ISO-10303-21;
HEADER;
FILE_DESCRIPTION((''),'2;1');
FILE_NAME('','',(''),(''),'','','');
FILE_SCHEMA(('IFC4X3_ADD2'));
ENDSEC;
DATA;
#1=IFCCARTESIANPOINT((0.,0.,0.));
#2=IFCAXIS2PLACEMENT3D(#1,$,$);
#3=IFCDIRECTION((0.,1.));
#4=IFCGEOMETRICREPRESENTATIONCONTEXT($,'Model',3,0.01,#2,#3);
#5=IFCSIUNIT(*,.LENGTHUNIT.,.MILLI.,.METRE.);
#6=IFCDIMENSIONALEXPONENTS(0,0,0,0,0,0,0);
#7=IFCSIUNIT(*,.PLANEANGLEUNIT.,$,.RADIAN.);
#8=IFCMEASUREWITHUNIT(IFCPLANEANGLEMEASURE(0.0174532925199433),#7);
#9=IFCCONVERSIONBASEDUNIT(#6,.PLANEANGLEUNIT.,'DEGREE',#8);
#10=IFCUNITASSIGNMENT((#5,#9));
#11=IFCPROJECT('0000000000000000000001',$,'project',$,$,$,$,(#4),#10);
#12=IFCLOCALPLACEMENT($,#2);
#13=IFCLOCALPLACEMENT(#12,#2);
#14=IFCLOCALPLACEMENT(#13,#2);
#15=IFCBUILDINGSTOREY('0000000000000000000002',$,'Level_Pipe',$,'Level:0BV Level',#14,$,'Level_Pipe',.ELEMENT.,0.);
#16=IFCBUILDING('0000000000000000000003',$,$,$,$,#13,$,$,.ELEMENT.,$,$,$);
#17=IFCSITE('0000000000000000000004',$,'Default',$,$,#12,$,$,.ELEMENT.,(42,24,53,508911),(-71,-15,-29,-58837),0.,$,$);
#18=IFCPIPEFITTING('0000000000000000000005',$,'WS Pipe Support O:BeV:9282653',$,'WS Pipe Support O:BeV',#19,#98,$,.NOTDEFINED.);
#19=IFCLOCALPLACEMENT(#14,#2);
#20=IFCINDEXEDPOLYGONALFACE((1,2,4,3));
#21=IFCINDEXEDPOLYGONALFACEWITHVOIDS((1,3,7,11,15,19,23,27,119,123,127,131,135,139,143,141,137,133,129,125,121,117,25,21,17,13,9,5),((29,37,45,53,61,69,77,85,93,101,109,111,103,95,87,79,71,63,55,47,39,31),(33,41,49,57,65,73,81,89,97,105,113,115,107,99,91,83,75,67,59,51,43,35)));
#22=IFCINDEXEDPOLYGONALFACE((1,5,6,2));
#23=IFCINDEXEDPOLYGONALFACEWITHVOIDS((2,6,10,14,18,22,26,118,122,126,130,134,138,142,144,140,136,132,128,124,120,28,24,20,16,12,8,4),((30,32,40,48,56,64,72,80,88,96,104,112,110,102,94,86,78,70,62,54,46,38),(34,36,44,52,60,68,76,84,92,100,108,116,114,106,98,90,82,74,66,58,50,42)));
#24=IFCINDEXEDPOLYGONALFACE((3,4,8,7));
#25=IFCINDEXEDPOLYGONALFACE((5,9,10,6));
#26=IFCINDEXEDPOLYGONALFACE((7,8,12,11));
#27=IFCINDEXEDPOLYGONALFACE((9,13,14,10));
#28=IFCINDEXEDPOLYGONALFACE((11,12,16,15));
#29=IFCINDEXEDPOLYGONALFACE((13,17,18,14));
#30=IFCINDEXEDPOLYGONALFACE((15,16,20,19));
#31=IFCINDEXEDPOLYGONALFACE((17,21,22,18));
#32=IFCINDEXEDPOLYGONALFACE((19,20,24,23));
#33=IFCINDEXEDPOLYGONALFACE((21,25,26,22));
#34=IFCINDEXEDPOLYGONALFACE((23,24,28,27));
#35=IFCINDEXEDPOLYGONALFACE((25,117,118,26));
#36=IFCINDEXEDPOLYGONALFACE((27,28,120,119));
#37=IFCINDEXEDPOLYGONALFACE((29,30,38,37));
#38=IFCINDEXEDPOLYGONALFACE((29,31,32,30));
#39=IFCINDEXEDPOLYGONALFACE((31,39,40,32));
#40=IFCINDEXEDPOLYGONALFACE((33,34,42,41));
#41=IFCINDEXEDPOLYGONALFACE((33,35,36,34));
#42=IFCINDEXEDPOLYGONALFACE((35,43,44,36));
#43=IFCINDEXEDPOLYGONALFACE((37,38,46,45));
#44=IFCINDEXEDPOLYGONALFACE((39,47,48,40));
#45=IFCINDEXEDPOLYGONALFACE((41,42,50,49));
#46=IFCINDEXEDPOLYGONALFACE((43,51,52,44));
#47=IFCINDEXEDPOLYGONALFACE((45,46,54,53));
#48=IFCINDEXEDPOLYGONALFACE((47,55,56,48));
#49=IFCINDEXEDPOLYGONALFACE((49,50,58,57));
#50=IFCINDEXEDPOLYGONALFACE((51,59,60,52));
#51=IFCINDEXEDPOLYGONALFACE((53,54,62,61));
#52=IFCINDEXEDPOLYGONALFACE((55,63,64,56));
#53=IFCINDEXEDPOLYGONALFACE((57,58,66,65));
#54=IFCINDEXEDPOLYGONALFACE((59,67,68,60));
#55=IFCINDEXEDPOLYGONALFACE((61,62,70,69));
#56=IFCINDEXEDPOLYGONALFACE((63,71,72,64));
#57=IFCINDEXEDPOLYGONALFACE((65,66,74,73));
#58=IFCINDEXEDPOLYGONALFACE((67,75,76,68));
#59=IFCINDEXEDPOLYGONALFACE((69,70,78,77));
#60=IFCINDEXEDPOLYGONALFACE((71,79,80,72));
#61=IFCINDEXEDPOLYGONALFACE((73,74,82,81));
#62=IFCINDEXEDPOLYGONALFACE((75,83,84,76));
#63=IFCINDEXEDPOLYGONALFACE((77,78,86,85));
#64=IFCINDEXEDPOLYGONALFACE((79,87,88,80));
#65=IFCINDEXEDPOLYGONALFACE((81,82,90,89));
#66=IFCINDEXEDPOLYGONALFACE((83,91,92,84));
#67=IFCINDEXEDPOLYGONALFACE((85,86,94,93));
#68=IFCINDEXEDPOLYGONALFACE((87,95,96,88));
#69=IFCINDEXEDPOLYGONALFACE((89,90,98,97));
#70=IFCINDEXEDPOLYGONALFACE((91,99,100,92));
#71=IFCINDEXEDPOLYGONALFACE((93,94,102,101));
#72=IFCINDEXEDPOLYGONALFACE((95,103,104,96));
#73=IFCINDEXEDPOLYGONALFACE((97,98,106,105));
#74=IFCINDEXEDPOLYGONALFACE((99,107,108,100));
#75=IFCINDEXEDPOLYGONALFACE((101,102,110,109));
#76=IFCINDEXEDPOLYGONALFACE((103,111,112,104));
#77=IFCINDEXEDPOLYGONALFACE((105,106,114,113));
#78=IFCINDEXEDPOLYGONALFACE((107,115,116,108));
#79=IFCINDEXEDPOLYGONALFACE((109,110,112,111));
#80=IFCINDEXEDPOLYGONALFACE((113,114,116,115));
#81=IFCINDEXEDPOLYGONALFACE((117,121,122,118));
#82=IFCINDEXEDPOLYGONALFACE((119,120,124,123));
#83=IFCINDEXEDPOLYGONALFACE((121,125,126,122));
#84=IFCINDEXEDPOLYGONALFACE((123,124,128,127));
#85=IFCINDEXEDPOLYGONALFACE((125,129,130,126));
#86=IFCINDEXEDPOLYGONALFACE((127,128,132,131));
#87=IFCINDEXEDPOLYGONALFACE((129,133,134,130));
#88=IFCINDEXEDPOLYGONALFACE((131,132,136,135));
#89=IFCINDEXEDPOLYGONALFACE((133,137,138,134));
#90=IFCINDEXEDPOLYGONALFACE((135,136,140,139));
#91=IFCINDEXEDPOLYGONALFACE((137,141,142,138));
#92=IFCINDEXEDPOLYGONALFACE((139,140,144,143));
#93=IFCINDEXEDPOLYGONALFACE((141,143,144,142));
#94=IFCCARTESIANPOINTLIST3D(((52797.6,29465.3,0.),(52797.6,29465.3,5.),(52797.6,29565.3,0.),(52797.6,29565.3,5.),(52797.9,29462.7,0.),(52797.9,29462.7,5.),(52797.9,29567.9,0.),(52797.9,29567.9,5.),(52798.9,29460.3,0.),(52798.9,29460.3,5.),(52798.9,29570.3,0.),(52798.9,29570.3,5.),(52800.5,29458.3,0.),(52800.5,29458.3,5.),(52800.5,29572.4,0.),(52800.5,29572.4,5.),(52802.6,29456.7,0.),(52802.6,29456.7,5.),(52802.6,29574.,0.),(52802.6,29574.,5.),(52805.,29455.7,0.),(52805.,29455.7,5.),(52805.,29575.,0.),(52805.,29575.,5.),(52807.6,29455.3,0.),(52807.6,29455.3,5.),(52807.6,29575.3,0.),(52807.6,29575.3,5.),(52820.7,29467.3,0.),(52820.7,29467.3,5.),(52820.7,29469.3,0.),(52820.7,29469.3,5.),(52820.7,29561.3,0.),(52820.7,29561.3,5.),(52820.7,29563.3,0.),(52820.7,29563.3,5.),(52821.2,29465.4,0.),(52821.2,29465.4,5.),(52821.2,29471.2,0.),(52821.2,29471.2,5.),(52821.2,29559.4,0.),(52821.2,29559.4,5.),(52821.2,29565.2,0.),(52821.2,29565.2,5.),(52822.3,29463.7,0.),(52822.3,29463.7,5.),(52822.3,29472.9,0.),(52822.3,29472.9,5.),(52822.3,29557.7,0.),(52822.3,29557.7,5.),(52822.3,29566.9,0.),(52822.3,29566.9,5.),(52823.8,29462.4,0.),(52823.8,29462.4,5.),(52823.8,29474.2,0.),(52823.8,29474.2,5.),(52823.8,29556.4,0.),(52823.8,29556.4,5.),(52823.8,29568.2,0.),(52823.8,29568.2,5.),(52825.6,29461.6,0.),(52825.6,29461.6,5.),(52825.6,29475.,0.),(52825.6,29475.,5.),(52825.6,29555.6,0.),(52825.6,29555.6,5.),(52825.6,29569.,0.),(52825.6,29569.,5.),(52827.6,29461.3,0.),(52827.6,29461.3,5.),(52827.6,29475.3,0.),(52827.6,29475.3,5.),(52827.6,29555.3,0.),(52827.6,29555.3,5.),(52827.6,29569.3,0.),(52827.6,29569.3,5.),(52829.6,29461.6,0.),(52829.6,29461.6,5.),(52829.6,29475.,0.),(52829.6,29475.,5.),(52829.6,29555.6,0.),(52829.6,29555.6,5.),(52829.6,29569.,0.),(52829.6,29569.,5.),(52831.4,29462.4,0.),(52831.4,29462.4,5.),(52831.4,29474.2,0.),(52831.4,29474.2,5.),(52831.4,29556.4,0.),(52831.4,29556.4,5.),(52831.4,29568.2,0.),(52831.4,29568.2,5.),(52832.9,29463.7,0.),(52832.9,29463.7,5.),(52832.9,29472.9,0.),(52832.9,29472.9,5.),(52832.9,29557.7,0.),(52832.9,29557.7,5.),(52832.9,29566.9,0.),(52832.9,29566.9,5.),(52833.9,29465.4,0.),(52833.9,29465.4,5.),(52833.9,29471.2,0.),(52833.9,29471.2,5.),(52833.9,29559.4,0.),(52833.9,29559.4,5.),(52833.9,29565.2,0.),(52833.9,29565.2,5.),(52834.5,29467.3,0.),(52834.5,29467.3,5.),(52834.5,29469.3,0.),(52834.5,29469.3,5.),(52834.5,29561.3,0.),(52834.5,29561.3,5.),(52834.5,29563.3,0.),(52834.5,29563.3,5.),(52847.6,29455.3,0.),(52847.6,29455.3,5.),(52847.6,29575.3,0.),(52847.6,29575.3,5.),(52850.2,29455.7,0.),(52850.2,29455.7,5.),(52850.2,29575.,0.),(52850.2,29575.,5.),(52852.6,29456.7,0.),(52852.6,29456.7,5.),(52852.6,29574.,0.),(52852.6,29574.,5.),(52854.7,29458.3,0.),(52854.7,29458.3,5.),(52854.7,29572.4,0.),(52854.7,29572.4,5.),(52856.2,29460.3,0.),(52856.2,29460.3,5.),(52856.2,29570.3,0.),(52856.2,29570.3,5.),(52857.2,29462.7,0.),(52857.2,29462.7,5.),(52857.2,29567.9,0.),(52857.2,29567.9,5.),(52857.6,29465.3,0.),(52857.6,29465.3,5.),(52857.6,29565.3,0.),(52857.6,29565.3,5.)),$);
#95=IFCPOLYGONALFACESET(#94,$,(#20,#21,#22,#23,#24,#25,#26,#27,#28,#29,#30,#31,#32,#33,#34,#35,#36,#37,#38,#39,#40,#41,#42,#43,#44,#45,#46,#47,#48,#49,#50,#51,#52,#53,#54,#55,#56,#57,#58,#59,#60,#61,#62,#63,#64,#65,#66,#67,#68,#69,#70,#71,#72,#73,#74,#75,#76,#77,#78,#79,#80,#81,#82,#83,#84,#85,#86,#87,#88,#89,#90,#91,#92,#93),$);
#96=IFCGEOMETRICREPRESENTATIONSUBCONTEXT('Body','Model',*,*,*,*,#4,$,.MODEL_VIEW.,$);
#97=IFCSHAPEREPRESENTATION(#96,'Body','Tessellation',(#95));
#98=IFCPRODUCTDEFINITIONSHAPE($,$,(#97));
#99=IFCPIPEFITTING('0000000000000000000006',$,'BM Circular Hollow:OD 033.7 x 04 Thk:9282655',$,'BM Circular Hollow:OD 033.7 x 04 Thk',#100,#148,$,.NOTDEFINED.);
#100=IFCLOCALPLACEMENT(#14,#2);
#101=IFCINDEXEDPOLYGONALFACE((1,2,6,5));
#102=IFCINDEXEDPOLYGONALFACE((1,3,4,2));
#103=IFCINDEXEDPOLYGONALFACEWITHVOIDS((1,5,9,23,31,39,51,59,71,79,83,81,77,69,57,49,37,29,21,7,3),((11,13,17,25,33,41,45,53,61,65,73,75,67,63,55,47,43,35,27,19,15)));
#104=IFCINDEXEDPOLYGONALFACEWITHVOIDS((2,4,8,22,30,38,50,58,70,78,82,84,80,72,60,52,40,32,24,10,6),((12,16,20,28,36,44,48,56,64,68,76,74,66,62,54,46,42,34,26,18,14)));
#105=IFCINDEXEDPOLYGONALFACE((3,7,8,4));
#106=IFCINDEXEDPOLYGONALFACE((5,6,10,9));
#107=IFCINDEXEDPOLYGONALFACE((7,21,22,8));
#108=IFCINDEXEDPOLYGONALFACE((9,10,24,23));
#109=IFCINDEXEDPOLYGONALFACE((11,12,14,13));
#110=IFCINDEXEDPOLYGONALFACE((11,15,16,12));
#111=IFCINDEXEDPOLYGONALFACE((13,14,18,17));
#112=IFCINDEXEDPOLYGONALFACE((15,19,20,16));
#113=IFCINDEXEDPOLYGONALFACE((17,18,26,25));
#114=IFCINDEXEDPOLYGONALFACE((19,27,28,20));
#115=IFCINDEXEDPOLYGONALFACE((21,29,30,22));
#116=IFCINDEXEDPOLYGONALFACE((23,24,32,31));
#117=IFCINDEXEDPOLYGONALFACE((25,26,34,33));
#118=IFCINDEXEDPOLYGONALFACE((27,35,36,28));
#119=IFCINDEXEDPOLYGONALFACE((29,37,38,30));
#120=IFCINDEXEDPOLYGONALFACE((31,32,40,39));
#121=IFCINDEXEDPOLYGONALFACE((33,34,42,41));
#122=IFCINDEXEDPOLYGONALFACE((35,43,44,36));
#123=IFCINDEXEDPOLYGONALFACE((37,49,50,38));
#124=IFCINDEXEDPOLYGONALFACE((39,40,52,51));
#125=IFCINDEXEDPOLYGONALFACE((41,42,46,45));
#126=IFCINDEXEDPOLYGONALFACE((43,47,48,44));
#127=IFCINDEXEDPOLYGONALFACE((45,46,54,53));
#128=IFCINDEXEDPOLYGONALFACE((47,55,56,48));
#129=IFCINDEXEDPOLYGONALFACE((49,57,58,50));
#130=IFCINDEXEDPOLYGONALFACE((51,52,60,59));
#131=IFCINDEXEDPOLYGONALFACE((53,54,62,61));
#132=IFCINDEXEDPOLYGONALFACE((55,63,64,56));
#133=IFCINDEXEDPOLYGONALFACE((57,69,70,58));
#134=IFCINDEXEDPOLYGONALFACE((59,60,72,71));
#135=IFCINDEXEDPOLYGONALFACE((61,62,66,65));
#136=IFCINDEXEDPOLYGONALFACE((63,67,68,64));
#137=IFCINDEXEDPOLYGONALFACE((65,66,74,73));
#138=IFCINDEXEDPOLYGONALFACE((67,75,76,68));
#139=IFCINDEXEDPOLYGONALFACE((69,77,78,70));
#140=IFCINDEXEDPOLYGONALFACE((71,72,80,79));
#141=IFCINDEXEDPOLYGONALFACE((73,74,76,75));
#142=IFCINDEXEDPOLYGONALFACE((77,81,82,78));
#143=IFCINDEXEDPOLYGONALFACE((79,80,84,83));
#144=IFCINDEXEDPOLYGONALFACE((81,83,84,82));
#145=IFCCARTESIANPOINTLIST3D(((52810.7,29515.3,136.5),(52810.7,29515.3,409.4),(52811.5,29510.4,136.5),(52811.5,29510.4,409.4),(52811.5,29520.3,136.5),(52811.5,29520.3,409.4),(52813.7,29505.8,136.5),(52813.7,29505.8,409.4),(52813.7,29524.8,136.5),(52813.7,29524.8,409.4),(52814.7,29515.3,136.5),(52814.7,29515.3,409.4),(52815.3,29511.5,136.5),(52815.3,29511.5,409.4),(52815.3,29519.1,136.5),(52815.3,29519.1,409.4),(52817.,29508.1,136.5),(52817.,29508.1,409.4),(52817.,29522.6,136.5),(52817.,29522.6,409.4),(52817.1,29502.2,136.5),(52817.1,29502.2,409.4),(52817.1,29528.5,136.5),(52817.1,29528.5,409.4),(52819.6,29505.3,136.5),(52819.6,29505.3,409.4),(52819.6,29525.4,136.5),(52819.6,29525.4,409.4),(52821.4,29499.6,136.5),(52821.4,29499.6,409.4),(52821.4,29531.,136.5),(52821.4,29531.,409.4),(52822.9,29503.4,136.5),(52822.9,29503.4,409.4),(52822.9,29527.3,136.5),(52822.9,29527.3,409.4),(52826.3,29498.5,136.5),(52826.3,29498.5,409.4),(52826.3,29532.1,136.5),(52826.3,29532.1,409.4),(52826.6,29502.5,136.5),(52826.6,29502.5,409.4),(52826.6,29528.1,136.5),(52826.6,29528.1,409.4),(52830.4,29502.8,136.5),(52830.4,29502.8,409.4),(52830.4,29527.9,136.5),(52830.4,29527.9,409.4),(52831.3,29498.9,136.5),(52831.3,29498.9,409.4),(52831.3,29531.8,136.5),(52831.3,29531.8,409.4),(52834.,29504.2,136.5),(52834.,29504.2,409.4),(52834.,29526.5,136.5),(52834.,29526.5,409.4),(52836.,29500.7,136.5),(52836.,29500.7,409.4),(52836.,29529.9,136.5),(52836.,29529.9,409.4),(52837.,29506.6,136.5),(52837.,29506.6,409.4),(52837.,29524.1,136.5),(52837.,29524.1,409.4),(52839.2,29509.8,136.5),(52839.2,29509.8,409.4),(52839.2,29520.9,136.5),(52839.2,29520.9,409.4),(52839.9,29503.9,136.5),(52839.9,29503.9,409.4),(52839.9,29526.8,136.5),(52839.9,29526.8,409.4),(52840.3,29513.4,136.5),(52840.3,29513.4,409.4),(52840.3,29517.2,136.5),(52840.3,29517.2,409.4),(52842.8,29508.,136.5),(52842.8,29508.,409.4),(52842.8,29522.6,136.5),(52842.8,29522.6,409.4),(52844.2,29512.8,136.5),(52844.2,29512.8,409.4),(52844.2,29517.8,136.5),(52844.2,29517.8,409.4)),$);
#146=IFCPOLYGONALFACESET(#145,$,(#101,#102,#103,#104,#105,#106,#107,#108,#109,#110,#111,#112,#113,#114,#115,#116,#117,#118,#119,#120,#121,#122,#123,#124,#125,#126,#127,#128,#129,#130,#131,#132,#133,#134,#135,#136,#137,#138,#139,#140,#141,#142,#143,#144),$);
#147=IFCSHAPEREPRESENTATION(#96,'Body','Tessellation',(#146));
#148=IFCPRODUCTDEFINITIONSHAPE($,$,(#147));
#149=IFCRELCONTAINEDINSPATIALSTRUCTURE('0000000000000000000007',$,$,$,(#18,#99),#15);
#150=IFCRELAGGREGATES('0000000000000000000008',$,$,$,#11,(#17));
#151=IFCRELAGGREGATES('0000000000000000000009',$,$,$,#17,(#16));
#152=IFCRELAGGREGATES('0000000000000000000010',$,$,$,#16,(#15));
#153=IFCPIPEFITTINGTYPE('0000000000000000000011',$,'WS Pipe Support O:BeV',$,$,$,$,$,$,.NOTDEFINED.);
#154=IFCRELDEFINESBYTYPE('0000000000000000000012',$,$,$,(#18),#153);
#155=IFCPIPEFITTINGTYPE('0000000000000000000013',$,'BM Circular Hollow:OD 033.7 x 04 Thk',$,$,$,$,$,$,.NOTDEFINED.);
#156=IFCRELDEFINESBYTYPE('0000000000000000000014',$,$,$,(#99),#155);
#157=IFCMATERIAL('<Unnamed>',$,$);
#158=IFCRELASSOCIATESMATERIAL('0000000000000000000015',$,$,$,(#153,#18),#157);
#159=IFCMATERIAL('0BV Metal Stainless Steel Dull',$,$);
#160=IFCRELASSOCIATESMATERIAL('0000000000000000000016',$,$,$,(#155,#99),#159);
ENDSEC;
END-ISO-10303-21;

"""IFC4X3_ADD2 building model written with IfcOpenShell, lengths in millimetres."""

from ifc_helpers import new_model, entity, si_unit, converted_unit, direction, frame, frame_2d, origin, place, context, subcontext, project, spatial, polyline, circle_curve, parameter, trimmed, segment, composite_curve, hollow_circle, outline, extrude, source, transform, mapped, material, type_object, type_shapes, element, save


model = new_model("IFC4X3_ADD2")

# Units and contexts
model_context = context("Model", 3, precision=0.01, world=origin(), true_north=direction((0.0, 1.0)))
body_context = subcontext(model_context, "Body", "Model", "MODEL_VIEW")
ifc_project = project(units=[si_unit("LENGTHUNIT", "METRE", prefix="MILLI"), converted_unit("PLANEANGLEUNIT", "DEGREE", entity("IfcPlaneAngleMeasure", 0.0174532925199433), si_unit("PLANEANGLEUNIT", "RADIAN"), dimensions=[0, 0, 0, 0, 0, 0, 0])], contexts=[model_context])

# Site, building, storey
site_placement = place(None, origin())
site = spatial("IfcSite", under=ifc_project, at=site_placement, Name="Default", CompositionType="ELEMENT", RefLatitude=(42, 24, 53, 508911), RefLongitude=(-71, -15, -29, -58837), RefElevation=0.0)
building_placement = place(site_placement, origin())
building = spatial("IfcBuilding", under=site, at=building_placement, CompositionType="ELEMENT")
storey_placement = place(building_placement, origin())
storey = spatial("IfcBuildingStorey", under=building, at=storey_placement, Name="Level_Pipe", ObjectType="Level:0BV Level", LongName="Level_Pipe", CompositionType="ELEMENT", Elevation=0.0)

# Shared definitions
ifc_material_1 = material(Name="0BV Metal Stainless Steel Dull")
ifc_material_2 = material(Name="<Unnamed>")

# Pipe fittings
pipe_fitting_type_1 = type_object("IfcPipeFittingType", Name="WS Pipe Support O:BeV", PredefinedType="NOTDEFINED", material=ifc_material_2)
shared_shape_1 = source(origin(), body_context, "Body", "SweptSolid", [
    extrude(outline(composite_curve([segment(trimmed(circle_curve(frame_2d((50.0, -20.0), x_axis=(1.0, 0.0)), 10.0), [parameter(270.0)], [parameter(0.0)], True, "PARAMETER"), True, "CONTINUOUS"), segment(polyline([(60.0, -20.0), (60.0, 20.0)]), True, "CONTINUOUS"), segment(trimmed(circle_curve(frame_2d((50.0, 20.0), x_axis=(1.0, 0.0)), 10.0), [parameter(0.0)], [parameter(90.0)], True, "PARAMETER"), True, "CONTINUOUS"), segment(polyline([(50.0, 30.0), (-50.0, 30.0)]), True, "CONTINUOUS"), segment(trimmed(circle_curve(frame_2d((-50.0, 20.0), x_axis=(1.0, 0.0)), 10.0), [parameter(90.0)], [parameter(180.0)], True, "PARAMETER"), True, "CONTINUOUS"), segment(polyline([(-60.0, 20.0), (-60.0, -20.0)]), True, "CONTINUOUS"), segment(trimmed(circle_curve(frame_2d((-50.0, -20.0), x_axis=(1.0, 0.0)), 10.0), [parameter(180.0)], [parameter(270.0)], True, "PARAMETER"), True, "CONTINUOUS"), segment(polyline([(-50.0, -30.0), (50.0, -30.0)]), True, "CONTINUOUS")], self_intersect=False), holes=[composite_curve([segment(trimmed(circle_curve(frame_2d((-47.0, 0.0), x_axis=(1.0, 0.0)), 7.0), [parameter(0.0)], [parameter(180.0)], True, "PARAMETER"), False, "CONTINUOUS"), segment(trimmed(circle_curve(frame_2d((-47.0, 0.0), x_axis=(1.0, 0.0)), 7.0), [parameter(180.0)], [parameter(360.0)], True, "PARAMETER"), False, "CONTINUOUS")], self_intersect=False), composite_curve([segment(trimmed(circle_curve(frame_2d((47.0, 0.0), x_axis=(1.0, 0.0)), 7.0), [parameter(0.0)], [parameter(180.0)], True, "PARAMETER"), False, "CONTINUOUS"), segment(trimmed(circle_curve(frame_2d((47.0, 0.0), x_axis=(1.0, 0.0)), 7.0), [parameter(180.0)], [parameter(360.0)], True, "PARAMETER"), False, "CONTINUOUS")], self_intersect=False)]), origin(), (0.0, 0.0, 1.0), 5.0),
])
type_shapes(pipe_fitting_type_1, [shared_shape_1])
pipe_fitting_1_placement = place(storey_placement, frame((52827.6, 29515.3, 0.0), z_axis=(0.0, 0.0, 1.0), x_axis=(0.0, -1.0, 0.0)))
element("IfcPipeFitting", 1, at=pipe_fitting_1_placement, inside=storey, type_object=pipe_fitting_type_1, material=ifc_material_2, Name="WS Pipe Support O:BeV:9282653", ObjectType="WS Pipe Support O:BeV", PredefinedType="NOTDEFINED", context=body_context, shape_type="MappedRepresentation", body=[
    mapped(shared_shape_1, transform((0.0, 0.0, 0.0), scale=1.0)),
])
pipe_fitting_type_2 = type_object("IfcPipeFittingType", Name="BM Circular Hollow:OD 033.7 x 04 Thk", PredefinedType="NOTDEFINED", material=ifc_material_1)
shared_shape_2 = source(origin(), body_context, "Body", "SweptSolid", [
    extrude(hollow_circle(Radius=16.9, WallThickness=4.0, at=frame_2d((0.0, 0.0), x_axis=(1.0, 0.0))), frame((-136.5, 0.0, 0.0), z_axis=(1.0, 0.0, 0.0), x_axis=(0.0, -1.0, 0.0)), (0.0, 0.0, 1.0), 272.9),
])
type_shapes(pipe_fitting_type_2, [shared_shape_2])
pipe_fitting_2_placement = place(storey_placement, frame((52827.6, 29515.3, 272.9), z_axis=(0.0, 1.0, 0.0), x_axis=(0.0, 0.0, 1.0)))
element("IfcPipeFitting", 2, at=pipe_fitting_2_placement, inside=storey, type_object=pipe_fitting_type_2, material=ifc_material_1, Name="BM Circular Hollow:OD 033.7 x 04 Thk:9282655", ObjectType="BM Circular Hollow:OD 033.7 x 04 Thk", PredefinedType="NOTDEFINED", context=body_context, shape_type="MappedRepresentation", body=[
    mapped(shared_shape_2, transform((0.0, 0.0, 0.0), scale=1.0)),
])

save(model, "model.ifc")
